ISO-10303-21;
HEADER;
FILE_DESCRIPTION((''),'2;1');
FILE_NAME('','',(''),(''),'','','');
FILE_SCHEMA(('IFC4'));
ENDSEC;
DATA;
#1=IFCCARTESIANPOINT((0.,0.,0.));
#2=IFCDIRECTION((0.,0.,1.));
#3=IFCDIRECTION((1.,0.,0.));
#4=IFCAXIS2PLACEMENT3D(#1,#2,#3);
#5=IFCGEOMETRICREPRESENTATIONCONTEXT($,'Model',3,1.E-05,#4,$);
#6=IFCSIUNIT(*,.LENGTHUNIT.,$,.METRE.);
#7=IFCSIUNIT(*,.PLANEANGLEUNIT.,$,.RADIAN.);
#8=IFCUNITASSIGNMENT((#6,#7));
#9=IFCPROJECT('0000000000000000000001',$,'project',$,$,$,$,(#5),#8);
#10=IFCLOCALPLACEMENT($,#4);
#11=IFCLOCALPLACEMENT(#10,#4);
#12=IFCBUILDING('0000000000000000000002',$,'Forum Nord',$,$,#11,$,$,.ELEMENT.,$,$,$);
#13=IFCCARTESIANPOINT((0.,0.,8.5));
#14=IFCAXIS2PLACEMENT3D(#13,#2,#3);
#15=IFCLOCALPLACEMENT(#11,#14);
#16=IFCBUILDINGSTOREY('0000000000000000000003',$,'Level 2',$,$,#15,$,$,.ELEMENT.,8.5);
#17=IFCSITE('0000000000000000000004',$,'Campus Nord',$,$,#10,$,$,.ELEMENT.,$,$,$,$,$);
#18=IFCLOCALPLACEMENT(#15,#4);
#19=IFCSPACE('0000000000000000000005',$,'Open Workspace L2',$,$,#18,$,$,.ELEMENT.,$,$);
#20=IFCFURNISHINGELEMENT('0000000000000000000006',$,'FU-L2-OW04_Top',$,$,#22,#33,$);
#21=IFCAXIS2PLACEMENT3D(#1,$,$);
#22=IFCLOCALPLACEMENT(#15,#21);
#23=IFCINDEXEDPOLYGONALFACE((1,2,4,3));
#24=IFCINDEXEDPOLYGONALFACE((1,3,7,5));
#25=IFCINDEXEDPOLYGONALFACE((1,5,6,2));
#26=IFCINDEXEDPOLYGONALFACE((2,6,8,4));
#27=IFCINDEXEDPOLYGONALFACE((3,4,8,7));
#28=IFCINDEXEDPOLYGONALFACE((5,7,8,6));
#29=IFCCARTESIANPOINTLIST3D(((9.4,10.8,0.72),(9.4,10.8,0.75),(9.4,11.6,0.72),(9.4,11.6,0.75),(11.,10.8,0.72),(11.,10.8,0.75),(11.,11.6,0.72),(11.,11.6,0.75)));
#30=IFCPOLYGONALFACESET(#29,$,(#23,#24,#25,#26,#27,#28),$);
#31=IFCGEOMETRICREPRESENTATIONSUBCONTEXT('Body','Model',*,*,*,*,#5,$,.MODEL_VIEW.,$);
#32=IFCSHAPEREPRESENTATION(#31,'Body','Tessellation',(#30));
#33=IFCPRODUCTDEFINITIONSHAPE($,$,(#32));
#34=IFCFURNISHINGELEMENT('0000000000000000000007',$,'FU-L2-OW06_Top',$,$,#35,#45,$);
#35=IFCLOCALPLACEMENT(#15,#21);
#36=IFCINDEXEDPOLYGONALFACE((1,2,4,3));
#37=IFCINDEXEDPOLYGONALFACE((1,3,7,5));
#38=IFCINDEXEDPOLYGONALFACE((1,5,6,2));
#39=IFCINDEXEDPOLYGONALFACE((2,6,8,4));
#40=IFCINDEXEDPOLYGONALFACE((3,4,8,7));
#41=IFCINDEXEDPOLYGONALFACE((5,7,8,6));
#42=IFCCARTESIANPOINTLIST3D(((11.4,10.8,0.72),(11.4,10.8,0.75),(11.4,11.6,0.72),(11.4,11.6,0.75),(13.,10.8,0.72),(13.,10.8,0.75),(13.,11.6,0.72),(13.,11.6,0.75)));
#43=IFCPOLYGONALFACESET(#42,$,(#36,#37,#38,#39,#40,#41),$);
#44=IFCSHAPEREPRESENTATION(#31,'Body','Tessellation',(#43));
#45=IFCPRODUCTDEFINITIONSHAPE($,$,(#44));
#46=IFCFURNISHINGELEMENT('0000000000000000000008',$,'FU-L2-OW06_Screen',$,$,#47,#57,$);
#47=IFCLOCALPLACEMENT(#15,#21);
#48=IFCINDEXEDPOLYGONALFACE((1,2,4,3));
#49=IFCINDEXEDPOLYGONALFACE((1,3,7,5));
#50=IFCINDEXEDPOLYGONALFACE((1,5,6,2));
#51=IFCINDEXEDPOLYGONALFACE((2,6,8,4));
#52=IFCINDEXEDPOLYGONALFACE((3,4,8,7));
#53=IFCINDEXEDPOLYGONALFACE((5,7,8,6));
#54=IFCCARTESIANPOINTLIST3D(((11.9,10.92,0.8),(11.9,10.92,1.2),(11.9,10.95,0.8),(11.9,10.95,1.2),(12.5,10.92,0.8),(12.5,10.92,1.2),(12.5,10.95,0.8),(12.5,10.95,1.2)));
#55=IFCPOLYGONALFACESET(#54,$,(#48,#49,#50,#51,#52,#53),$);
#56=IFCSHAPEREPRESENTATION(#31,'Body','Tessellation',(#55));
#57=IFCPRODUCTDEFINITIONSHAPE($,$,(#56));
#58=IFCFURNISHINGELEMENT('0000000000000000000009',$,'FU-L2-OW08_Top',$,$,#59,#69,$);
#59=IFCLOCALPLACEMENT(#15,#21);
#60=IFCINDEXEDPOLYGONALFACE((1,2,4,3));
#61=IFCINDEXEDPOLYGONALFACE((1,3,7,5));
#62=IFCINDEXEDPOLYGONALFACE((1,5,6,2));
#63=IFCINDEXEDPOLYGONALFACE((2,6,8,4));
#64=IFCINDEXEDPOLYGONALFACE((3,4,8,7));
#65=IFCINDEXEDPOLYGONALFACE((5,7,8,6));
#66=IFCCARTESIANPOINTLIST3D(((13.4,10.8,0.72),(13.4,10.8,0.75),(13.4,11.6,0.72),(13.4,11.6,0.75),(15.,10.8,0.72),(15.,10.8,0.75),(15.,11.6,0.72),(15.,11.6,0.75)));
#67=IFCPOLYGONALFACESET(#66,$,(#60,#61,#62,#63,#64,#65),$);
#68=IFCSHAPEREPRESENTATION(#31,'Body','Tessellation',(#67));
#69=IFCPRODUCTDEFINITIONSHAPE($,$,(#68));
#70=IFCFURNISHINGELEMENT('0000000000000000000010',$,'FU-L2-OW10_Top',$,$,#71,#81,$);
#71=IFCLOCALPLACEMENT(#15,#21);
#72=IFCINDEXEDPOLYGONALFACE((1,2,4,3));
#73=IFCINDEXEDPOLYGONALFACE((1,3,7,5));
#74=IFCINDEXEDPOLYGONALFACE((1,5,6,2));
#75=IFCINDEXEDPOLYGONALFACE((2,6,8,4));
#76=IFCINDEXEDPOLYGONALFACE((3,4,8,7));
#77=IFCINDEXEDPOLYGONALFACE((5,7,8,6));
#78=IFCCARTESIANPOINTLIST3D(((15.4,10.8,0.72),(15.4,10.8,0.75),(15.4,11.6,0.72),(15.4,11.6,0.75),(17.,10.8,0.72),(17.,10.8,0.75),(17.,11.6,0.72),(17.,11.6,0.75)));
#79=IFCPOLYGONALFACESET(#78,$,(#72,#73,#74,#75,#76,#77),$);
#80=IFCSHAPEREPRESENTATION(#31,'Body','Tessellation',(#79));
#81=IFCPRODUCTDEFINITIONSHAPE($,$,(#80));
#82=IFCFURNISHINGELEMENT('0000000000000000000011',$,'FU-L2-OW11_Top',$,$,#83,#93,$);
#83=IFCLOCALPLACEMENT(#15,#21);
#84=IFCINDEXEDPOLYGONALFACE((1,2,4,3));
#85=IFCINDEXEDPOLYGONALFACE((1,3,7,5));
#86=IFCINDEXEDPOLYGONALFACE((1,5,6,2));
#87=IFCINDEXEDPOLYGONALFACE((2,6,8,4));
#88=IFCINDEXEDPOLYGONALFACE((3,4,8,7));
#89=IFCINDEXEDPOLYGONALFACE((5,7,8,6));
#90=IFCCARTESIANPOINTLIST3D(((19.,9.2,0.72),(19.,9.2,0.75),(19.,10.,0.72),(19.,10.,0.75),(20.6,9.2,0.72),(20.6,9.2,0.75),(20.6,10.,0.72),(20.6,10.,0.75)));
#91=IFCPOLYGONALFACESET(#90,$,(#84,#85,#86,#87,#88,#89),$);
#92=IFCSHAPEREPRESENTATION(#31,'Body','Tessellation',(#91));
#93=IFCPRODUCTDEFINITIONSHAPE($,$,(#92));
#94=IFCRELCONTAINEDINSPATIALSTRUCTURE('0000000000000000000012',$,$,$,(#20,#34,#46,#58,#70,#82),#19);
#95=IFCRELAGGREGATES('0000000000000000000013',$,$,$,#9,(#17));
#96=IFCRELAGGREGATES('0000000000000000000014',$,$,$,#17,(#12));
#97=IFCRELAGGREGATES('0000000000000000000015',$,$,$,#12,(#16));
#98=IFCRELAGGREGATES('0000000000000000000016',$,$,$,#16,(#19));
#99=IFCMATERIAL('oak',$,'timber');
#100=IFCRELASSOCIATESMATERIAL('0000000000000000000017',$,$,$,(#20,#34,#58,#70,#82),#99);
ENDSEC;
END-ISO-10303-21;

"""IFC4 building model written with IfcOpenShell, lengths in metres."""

from ifc_helpers import new_model, si_unit, frame, frame_2d, origin_with_axes, place, context, subcontext, project, spatial, rectangle, extrude, material, element, save


model = new_model("IFC4")

# Units and contexts
model_context = context("Model", 3, precision=1e-05, world=origin_with_axes())
body_context = subcontext(model_context, "Body", "Model", "MODEL_VIEW")
ifc_project = project(units=[si_unit("LENGTHUNIT", "METRE"), si_unit("PLANEANGLEUNIT", "RADIAN")], contexts=[model_context])

# Site, building, storey, space
site_placement = place(None, origin_with_axes())
site = spatial("IfcSite", under=ifc_project, at=site_placement, Name="Campus Nord", CompositionType="ELEMENT")
building_placement = place(site_placement, origin_with_axes())
building = spatial("IfcBuilding", under=site, at=building_placement, Name="Forum Nord", CompositionType="ELEMENT")
storey_placement = place(building_placement, frame((0.0, 0.0, 8.5), z_axis=(0.0, 0.0, 1.0), x_axis=(1.0, 0.0, 0.0)))
storey = spatial("IfcBuildingStorey", under=building, at=storey_placement, Name="Level 2", CompositionType="ELEMENT", Elevation=8.5)
space_placement = place(storey_placement, origin_with_axes())
space = spatial("IfcSpace", under=storey, at=space_placement, Name="Open Workspace L2", CompositionType="ELEMENT")

# Furnishing elements
ifc_material = material(Name="oak", Category="timber")
furnishing_1_placement = place(storey_placement, frame((11.0, 12.2, 0.0), z_axis=(0.0, 0.0, 1.0), x_axis=(-1.0, 0.0, 0.0)))
element("IfcFurnishingElement", 1, at=furnishing_1_placement, inside=space, material=ifc_material, Name="FU-L2-OW04_Top", context=body_context, shape_type="SweptSolid", body=[
    extrude(rectangle(XDim=1.6, YDim=0.8, at=frame_2d((0.8, 1.0), x_axis=(1.0, 0.0))), frame((0.0, 0.0, 0.72), z_axis=(0.0, 0.0, 1.0), x_axis=(1.0, 0.0, 0.0)), (0.0, 0.0, 1.0), 0.03),
])
furnishing_2_placement = place(storey_placement, frame((13.0, 12.2, 0.0), z_axis=(0.0, 0.0, 1.0), x_axis=(-1.0, 0.0, 0.0)))
element("IfcFurnishingElement", 2, at=furnishing_2_placement, inside=space, material=ifc_material, Name="FU-L2-OW06_Top", context=body_context, shape_type="SweptSolid", body=[
    extrude(rectangle(XDim=1.6, YDim=0.8, at=frame_2d((0.8, 1.0), x_axis=(1.0, 0.0))), frame((0.0, 0.0, 0.72), z_axis=(0.0, 0.0, 1.0), x_axis=(1.0, 0.0, 0.0)), (0.0, 0.0, 1.0), 0.03),
])
furnishing_3_placement = place(storey_placement, frame((13.0, 12.2, 0.0), z_axis=(0.0, 0.0, 1.0), x_axis=(-1.0, 0.0, 0.0)))
element("IfcFurnishingElement", 3, at=furnishing_3_placement, inside=space, Name="FU-L2-OW06_Screen", context=body_context, shape_type="SweptSolid", body=[
    extrude(rectangle(XDim=0.6, YDim=0.03, at=frame_2d((0.8, 1.265), x_axis=(1.0, 0.0))), frame((0.0, 0.0, 0.8), z_axis=(0.0, 0.0, 1.0), x_axis=(1.0, 0.0, 0.0)), (0.0, 0.0, 1.0), 0.4),
])
furnishing_4_placement = place(storey_placement, frame((15.0, 12.2, 0.0), z_axis=(0.0, 0.0, 1.0), x_axis=(-1.0, 0.0, 0.0)))
element("IfcFurnishingElement", 4, at=furnishing_4_placement, inside=space, material=ifc_material, Name="FU-L2-OW08_Top", context=body_context, shape_type="SweptSolid", body=[
    extrude(rectangle(XDim=1.6, YDim=0.8, at=frame_2d((0.8, 1.0), x_axis=(1.0, 0.0))), frame((0.0, 0.0, 0.72), z_axis=(0.0, 0.0, 1.0), x_axis=(1.0, 0.0, 0.0)), (0.0, 0.0, 1.0), 0.03),
])
furnishing_5_placement = place(storey_placement, frame((17.0, 12.2, 0.0), z_axis=(0.0, 0.0, 1.0), x_axis=(-1.0, 0.0, 0.0)))
element("IfcFurnishingElement", 5, at=furnishing_5_placement, inside=space, material=ifc_material, Name="FU-L2-OW10_Top", context=body_context, shape_type="SweptSolid", body=[
    extrude(rectangle(XDim=1.6, YDim=0.8, at=frame_2d((0.8, 1.0), x_axis=(1.0, 0.0))), frame((0.0, 0.0, 0.72), z_axis=(0.0, 0.0, 1.0), x_axis=(1.0, 0.0, 0.0)), (0.0, 0.0, 1.0), 0.03),
])
furnishing_6_placement = place(storey_placement, frame((19.0, 8.6, 0.0), z_axis=(0.0, 0.0, 1.0), x_axis=(1.0, 0.0, 0.0)))
element("IfcFurnishingElement", 6, at=furnishing_6_placement, inside=space, material=ifc_material, Name="FU-L2-OW11_Top", context=body_context, shape_type="SweptSolid", body=[
    extrude(rectangle(XDim=1.6, YDim=0.8, at=frame_2d((0.8, 1.0), x_axis=(1.0, 0.0))), frame((0.0, 0.0, 0.72), z_axis=(0.0, 0.0, 1.0), x_axis=(1.0, 0.0, 0.0)), (0.0, 0.0, 1.0), 0.03),
])

save(model, "model.ifc")
